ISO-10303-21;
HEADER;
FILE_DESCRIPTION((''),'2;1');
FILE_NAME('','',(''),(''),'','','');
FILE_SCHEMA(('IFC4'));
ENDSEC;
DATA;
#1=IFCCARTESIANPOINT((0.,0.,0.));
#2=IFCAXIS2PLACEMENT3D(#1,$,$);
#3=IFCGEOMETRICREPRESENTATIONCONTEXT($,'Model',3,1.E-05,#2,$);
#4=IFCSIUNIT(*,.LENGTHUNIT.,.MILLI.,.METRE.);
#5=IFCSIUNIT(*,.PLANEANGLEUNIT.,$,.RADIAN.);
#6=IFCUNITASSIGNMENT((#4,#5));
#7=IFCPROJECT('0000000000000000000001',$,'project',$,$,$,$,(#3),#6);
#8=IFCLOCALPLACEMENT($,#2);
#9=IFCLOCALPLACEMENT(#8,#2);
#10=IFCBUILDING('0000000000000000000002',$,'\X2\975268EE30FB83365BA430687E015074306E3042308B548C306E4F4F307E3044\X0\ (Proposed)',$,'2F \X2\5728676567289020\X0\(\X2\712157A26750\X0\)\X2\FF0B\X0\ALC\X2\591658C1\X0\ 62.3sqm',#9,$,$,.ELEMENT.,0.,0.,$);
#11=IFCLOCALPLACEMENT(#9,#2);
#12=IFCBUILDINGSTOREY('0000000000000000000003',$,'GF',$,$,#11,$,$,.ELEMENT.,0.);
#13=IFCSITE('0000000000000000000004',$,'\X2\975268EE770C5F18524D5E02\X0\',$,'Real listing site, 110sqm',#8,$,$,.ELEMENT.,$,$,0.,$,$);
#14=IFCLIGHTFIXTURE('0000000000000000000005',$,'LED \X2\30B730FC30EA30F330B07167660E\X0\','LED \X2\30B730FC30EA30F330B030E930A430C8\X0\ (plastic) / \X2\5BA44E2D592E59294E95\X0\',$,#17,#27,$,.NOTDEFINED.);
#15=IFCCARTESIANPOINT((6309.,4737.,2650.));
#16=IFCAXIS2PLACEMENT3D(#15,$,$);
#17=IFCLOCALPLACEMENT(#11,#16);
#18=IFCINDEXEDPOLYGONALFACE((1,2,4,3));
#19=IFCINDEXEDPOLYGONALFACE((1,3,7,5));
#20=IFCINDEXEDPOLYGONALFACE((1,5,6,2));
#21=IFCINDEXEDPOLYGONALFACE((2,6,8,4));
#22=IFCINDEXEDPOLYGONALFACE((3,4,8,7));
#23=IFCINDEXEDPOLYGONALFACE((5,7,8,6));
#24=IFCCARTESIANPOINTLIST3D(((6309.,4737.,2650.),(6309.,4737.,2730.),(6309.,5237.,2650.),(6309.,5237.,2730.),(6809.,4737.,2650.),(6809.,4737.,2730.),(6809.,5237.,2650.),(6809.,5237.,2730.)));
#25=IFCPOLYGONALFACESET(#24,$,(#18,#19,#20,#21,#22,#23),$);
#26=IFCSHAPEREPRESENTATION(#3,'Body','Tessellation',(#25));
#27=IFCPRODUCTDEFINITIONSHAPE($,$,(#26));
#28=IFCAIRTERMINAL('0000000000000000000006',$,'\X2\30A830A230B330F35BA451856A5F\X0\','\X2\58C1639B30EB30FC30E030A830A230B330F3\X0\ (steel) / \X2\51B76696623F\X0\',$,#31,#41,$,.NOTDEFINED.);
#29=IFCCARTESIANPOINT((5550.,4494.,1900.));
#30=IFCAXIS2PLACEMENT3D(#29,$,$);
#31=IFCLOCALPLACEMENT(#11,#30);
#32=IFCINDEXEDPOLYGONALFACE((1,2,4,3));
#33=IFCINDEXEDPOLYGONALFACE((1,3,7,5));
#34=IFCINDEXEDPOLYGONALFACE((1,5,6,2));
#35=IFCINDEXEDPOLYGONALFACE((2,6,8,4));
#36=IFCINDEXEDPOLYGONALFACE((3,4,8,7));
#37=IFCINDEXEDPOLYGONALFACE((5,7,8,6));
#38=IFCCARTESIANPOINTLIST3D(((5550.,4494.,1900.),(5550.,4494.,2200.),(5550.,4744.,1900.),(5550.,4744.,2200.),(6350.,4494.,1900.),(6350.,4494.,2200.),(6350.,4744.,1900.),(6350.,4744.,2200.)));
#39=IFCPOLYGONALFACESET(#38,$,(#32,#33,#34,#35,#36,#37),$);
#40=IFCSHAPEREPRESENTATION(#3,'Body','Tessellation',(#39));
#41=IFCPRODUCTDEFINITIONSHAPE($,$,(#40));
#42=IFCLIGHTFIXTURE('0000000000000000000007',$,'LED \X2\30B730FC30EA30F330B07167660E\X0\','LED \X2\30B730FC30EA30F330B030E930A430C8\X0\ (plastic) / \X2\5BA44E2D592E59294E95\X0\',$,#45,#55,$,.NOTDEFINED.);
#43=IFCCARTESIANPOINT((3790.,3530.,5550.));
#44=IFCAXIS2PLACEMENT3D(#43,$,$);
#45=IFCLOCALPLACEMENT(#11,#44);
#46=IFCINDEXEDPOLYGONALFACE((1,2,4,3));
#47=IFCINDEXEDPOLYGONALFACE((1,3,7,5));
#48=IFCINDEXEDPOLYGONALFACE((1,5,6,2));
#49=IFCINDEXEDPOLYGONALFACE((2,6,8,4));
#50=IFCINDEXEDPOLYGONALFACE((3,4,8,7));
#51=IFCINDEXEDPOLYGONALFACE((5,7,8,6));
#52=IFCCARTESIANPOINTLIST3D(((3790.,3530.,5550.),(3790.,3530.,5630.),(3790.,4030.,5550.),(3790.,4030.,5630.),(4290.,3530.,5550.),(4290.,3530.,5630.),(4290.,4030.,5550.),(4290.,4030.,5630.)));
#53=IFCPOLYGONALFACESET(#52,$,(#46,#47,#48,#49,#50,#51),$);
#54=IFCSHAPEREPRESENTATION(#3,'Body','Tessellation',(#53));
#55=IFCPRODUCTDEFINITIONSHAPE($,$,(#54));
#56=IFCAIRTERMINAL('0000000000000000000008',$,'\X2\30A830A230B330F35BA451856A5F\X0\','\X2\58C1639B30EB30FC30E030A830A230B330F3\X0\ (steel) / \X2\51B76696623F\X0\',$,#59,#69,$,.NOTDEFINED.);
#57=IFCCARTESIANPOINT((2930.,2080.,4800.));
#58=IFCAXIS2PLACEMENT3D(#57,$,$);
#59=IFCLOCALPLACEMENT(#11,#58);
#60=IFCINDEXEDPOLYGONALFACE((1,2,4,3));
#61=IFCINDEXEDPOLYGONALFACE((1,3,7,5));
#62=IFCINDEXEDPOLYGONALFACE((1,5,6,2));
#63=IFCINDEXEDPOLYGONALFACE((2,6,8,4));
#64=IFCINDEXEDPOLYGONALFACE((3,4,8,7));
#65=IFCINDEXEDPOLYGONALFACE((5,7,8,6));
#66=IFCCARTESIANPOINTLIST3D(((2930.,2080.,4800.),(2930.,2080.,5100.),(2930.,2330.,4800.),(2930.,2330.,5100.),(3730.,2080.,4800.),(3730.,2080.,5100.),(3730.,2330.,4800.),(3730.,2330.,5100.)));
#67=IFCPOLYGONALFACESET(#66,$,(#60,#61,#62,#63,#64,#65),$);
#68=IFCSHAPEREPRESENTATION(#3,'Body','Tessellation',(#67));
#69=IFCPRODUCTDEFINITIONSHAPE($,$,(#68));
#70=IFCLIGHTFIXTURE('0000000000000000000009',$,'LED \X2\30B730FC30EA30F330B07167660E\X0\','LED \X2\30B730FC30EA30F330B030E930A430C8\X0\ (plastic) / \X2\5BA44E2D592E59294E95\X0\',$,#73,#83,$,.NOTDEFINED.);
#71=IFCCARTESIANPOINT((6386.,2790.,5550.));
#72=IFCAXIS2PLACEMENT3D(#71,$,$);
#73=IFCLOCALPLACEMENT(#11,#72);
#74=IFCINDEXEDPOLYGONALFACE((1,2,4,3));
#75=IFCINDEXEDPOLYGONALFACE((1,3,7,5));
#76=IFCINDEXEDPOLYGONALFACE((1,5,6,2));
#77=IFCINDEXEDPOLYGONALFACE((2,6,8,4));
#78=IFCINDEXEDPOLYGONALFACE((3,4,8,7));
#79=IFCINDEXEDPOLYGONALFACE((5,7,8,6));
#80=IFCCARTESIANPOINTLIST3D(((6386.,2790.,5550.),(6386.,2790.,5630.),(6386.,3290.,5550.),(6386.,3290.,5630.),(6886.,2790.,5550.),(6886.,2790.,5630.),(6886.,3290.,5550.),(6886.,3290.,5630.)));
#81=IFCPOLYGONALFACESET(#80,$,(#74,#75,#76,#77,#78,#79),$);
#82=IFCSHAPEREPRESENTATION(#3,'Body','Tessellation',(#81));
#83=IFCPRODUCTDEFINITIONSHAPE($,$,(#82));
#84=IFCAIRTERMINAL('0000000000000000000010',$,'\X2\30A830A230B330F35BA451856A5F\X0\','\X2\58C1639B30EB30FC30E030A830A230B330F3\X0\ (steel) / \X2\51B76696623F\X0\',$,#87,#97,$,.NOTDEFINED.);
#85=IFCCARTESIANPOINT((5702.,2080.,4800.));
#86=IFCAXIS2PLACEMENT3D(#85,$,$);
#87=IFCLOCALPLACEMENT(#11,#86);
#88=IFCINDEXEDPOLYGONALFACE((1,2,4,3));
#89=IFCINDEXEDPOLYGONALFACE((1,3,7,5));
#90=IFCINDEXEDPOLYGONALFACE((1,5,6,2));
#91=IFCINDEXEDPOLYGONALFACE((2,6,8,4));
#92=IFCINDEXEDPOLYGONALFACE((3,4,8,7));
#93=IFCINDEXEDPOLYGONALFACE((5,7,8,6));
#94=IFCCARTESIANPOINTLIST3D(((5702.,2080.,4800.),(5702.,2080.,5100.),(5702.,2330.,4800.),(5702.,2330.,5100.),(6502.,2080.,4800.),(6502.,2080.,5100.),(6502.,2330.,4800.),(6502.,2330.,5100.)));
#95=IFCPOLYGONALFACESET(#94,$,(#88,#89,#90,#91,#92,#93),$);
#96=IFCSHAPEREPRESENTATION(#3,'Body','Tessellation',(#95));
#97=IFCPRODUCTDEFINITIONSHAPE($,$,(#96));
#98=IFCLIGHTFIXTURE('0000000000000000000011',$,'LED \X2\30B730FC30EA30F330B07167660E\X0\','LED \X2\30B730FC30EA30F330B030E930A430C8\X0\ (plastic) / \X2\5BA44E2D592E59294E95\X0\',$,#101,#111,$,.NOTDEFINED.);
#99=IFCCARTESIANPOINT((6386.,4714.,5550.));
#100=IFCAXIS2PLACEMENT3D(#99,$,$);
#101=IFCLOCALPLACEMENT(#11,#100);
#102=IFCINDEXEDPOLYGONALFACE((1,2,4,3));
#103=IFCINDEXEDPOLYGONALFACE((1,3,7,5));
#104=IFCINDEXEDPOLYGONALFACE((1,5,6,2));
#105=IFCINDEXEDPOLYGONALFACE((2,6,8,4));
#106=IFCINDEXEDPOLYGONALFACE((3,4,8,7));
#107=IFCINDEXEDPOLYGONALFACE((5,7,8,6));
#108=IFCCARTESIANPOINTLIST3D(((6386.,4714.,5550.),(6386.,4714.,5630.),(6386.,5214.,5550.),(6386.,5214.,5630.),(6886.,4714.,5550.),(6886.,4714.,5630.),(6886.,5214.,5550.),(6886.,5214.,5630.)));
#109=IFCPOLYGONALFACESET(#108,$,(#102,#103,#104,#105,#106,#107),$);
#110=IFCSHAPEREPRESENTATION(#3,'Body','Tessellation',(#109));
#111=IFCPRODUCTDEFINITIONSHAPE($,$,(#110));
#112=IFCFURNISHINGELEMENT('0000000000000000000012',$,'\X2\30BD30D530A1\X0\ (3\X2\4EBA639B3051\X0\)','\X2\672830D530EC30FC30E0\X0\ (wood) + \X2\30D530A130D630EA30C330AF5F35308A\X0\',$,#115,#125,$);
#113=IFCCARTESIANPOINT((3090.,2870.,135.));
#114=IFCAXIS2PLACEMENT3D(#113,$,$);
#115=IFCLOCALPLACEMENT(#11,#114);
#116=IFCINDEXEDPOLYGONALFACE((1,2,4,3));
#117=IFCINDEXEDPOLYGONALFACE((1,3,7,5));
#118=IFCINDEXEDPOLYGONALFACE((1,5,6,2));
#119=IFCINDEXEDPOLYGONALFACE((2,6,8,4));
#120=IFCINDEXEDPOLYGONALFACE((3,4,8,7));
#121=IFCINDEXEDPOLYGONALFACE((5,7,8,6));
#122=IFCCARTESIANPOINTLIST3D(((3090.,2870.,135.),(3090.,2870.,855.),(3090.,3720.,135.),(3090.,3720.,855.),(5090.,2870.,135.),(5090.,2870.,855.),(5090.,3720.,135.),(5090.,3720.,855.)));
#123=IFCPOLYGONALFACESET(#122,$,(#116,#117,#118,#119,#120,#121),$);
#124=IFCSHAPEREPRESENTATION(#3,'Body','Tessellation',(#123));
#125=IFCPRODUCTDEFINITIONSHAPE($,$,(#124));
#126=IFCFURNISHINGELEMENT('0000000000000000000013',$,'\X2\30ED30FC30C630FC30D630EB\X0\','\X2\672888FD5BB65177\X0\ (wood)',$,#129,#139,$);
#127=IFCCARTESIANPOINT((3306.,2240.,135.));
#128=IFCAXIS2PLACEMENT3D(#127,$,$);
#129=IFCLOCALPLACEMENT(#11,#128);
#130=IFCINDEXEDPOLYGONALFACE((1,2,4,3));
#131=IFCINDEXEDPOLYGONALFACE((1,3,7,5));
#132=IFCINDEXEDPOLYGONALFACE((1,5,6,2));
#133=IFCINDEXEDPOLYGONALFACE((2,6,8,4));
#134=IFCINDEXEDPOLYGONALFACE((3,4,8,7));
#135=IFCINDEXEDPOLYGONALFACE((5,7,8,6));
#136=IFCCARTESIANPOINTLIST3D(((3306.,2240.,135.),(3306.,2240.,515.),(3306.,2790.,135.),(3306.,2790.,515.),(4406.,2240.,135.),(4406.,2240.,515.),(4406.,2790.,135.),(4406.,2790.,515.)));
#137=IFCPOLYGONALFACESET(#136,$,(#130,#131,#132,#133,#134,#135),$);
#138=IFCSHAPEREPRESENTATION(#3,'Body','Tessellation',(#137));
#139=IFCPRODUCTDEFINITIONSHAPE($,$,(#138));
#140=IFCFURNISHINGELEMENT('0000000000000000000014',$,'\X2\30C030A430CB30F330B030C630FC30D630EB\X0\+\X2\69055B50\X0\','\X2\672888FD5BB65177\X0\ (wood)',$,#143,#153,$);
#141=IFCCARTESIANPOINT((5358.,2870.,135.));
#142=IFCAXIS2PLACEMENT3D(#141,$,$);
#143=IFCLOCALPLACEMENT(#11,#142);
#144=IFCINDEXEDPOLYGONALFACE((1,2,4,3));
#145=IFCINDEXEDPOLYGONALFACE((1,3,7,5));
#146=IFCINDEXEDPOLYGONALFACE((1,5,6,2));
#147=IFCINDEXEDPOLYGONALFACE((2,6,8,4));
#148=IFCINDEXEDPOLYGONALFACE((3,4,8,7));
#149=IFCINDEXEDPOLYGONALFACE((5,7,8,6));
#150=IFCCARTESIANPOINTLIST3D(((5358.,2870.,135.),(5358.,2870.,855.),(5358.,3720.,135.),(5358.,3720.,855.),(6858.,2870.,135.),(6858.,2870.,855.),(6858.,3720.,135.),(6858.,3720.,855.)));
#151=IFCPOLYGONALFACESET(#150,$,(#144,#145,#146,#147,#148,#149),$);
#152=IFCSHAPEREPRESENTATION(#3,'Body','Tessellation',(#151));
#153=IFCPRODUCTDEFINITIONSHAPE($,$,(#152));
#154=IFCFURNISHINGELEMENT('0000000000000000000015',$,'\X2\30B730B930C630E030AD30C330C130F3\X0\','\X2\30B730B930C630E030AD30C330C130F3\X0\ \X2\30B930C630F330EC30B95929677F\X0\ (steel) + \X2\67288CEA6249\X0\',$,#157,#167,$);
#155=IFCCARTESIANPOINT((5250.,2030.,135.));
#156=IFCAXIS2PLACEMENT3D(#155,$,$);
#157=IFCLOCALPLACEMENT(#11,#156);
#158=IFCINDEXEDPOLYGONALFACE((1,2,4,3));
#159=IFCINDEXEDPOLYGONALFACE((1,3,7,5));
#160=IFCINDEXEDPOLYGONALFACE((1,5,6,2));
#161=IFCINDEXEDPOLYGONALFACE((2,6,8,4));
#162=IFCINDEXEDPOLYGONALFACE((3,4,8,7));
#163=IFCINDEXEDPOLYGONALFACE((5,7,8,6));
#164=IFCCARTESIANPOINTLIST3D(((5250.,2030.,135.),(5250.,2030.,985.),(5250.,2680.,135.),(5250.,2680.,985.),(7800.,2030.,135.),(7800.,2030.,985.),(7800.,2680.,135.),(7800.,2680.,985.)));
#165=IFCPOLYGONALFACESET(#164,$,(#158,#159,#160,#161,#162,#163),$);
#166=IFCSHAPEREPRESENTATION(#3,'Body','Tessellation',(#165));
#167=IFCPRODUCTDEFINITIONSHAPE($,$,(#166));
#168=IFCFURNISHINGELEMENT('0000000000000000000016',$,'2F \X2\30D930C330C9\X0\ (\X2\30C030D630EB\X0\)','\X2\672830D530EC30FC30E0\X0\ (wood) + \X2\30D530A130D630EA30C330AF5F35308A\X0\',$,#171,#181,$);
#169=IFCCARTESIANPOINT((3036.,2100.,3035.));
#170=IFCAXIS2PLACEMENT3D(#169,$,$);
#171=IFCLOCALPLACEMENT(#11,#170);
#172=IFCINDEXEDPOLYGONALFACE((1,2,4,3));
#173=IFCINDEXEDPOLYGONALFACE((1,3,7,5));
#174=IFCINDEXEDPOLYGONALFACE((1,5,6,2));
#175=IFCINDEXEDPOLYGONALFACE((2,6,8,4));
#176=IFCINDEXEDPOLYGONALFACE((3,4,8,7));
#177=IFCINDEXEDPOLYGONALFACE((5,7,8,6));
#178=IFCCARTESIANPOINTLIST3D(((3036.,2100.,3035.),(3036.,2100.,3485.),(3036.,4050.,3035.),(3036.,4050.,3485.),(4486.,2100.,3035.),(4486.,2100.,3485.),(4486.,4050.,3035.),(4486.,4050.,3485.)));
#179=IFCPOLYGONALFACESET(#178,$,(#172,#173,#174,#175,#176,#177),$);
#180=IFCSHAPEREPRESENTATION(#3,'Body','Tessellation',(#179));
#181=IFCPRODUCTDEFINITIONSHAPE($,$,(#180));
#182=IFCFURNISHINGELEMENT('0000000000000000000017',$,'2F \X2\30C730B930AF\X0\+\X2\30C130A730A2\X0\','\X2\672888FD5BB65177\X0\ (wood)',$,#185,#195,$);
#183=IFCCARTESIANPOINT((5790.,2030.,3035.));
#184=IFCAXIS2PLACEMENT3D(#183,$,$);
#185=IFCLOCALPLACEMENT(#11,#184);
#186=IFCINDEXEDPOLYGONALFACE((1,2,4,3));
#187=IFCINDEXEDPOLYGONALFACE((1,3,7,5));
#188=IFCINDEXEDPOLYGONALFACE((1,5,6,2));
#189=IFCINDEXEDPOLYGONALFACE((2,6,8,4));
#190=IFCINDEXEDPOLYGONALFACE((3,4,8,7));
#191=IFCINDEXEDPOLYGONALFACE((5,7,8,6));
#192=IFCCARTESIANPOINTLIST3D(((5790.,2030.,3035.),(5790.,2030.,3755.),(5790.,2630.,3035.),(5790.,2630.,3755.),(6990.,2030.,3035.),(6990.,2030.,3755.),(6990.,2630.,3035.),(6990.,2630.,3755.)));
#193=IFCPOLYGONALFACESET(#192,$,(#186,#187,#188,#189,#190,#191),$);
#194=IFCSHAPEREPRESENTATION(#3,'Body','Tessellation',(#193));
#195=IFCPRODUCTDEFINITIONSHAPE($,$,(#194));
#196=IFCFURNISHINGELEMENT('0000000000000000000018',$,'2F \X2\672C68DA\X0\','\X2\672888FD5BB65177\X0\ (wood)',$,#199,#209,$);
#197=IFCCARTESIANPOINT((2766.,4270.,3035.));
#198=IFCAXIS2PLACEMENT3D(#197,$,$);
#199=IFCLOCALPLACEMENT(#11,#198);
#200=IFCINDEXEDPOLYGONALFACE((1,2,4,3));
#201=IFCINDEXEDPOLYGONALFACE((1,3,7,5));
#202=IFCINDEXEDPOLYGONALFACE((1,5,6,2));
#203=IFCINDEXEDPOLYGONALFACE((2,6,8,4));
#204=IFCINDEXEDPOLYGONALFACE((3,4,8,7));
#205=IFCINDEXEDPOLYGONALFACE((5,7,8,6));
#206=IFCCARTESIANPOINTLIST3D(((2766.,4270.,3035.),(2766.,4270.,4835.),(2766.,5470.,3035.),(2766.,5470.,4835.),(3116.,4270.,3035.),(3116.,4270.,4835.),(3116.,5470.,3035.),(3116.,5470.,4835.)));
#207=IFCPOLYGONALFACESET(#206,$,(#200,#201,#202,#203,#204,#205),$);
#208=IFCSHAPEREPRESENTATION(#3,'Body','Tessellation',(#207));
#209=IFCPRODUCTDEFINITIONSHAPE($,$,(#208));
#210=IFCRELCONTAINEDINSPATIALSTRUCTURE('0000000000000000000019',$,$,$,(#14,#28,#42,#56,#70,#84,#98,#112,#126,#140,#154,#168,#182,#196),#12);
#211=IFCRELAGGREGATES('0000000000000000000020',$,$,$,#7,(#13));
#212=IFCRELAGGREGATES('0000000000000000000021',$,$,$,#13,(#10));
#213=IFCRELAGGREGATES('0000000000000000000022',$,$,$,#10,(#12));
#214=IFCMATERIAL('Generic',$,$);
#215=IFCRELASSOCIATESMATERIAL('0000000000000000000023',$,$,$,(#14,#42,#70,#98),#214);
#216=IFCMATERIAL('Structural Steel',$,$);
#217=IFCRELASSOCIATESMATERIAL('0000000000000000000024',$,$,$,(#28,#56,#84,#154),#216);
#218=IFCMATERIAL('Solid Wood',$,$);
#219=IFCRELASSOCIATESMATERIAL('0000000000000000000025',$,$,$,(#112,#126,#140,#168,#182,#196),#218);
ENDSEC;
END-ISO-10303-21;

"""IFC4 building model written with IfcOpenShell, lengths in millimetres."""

from ifc_helpers import new_model, si_unit, frame, frame_2d, origin, place, context, project, spatial, rectangle, extrude, material, element, save


model = new_model("IFC4")

# Units and contexts
model_context = context("Model", 3, precision=1e-05, world=origin())
ifc_project = project(units=[si_unit("LENGTHUNIT", "METRE", prefix="MILLI"), si_unit("PLANEANGLEUNIT", "RADIAN")], contexts=[model_context])

# Site, building, storey
site_placement = place(None, origin())
site = spatial("IfcSite", under=ifc_project, at=site_placement, Name="青森県弘前市", ObjectType="Real listing site, 110sqm", CompositionType="ELEMENT", RefElevation=0.0)
building_placement = place(site_placement, origin())
building = spatial("IfcBuilding", under=site, at=building_placement, Name="青森・茶室と縁側のある和の住まい (Proposed)", ObjectType="2F 在来木造(無垢材)＋ALC外壁 62.3sqm", CompositionType="ELEMENT", ElevationOfRefHeight=0.0, ElevationOfTerrain=0.0)
storey_placement = place(building_placement, origin())
storey = spatial("IfcBuildingStorey", under=building, at=storey_placement, Name="GF", CompositionType="ELEMENT", Elevation=0.0)

# Shared definitions
ifc_material_1 = material(Name="Solid Wood")

# Shared definitions
ifc_material_2 = material(Name="Structural Steel")

# Shared definitions
ifc_material_3 = material(Name="Generic")

# Light fixture
light_fixture_1_placement = place(storey_placement, frame((6309.0, 4737.0, 2650.0)))
element("IfcLightFixture", 1, at=light_fixture_1_placement, inside=storey, material=ifc_material_3, Name="LED シーリング照明", Description="LED シーリングライト (plastic) / 室中央天井", PredefinedType="NOTDEFINED", context=model_context, shape_type="SweptSolid", body=[
    extrude(rectangle(XDim=500.0, YDim=500.0, at=frame_2d((250.0, 250.0))), frame((6309.0, 4737.0, 2650.0)), (0.0, 0.0, 1.0), 80.0),
])

# Air terminal
air_terminal_1_placement = place(storey_placement, frame((5550.0, 4494.0, 1900.0)))
element("IfcAirTerminal", 2, at=air_terminal_1_placement, inside=storey, material=ifc_material_2, Name="エアコン室内機", Description="壁掛ルームエアコン (steel) / 冷暖房", PredefinedType="NOTDEFINED", context=model_context, shape_type="SweptSolid", body=[
    extrude(rectangle(XDim=800.0, YDim=250.0, at=frame_2d((400.0, 125.0))), frame((5550.0, 4494.0, 1900.0)), (0.0, 0.0, 1.0), 300.0),
])

# Light fixture
light_fixture_2_placement = place(storey_placement, frame((3790.0, 3530.0, 5550.0)))
element("IfcLightFixture", 3, at=light_fixture_2_placement, inside=storey, material=ifc_material_3, Name="LED シーリング照明", Description="LED シーリングライト (plastic) / 室中央天井", PredefinedType="NOTDEFINED", context=model_context, shape_type="SweptSolid", body=[
    extrude(rectangle(XDim=500.0, YDim=500.0, at=frame_2d((250.0, 250.0))), frame((3790.0, 3530.0, 5550.0)), (0.0, 0.0, 1.0), 80.0),
])

# Air terminal
air_terminal_2_placement = place(storey_placement, frame((2930.0, 2080.0, 4800.0)))
element("IfcAirTerminal", 4, at=air_terminal_2_placement, inside=storey, material=ifc_material_2, Name="エアコン室内機", Description="壁掛ルームエアコン (steel) / 冷暖房", PredefinedType="NOTDEFINED", context=model_context, shape_type="SweptSolid", body=[
    extrude(rectangle(XDim=800.0, YDim=250.0, at=frame_2d((400.0, 125.0))), frame((2930.0, 2080.0, 4800.0)), (0.0, 0.0, 1.0), 300.0),
])

# Light fixture
light_fixture_3_placement = place(storey_placement, frame((6386.0, 2790.0, 5550.0)))
element("IfcLightFixture", 5, at=light_fixture_3_placement, inside=storey, material=ifc_material_3, Name="LED シーリング照明", Description="LED シーリングライト (plastic) / 室中央天井", PredefinedType="NOTDEFINED", context=model_context, shape_type="SweptSolid", body=[
    extrude(rectangle(XDim=500.0, YDim=500.0, at=frame_2d((250.0, 250.0))), frame((6386.0, 2790.0, 5550.0)), (0.0, 0.0, 1.0), 80.0),
])

# Air terminal
air_terminal_3_placement = place(storey_placement, frame((5702.0, 2080.0, 4800.0)))
element("IfcAirTerminal", 6, at=air_terminal_3_placement, inside=storey, material=ifc_material_2, Name="エアコン室内機", Description="壁掛ルームエアコン (steel) / 冷暖房", PredefinedType="NOTDEFINED", context=model_context, shape_type="SweptSolid", body=[
    extrude(rectangle(XDim=800.0, YDim=250.0, at=frame_2d((400.0, 125.0))), frame((5702.0, 2080.0, 4800.0)), (0.0, 0.0, 1.0), 300.0),
])

# Light fixture
light_fixture_4_placement = place(storey_placement, frame((6386.0, 4714.0, 5550.0)))
element("IfcLightFixture", 7, at=light_fixture_4_placement, inside=storey, material=ifc_material_3, Name="LED シーリング照明", Description="LED シーリングライト (plastic) / 室中央天井", PredefinedType="NOTDEFINED", context=model_context, shape_type="SweptSolid", body=[
    extrude(rectangle(XDim=500.0, YDim=500.0, at=frame_2d((250.0, 250.0))), frame((6386.0, 4714.0, 5550.0)), (0.0, 0.0, 1.0), 80.0),
])

# Furnishing elements
furnishing_1_placement = place(storey_placement, frame((3090.0, 2870.0, 135.0)))
element("IfcFurnishingElement", 8, at=furnishing_1_placement, inside=storey, material=ifc_material_1, Name="ソファ (3人掛け)", Description="木フレーム (wood) + ファブリック張り", context=model_context, shape_type="SweptSolid", body=[
    extrude(rectangle(XDim=2000.0, YDim=850.0, at=frame_2d((1000.0, 425.0))), frame((3090.0, 2870.0, 135.0)), (0.0, 0.0, 1.0), 720.0),
])
furnishing_2_placement = place(storey_placement, frame((3306.0, 2240.0, 135.0)))
element("IfcFurnishingElement", 9, at=furnishing_2_placement, inside=storey, material=ifc_material_1, Name="ローテーブル", Description="木製家具 (wood)", context=model_context, shape_type="SweptSolid", body=[
    extrude(rectangle(XDim=1100.0, YDim=550.0, at=frame_2d((550.0, 275.0))), frame((3306.0, 2240.0, 135.0)), (0.0, 0.0, 1.0), 380.0),
])
furnishing_3_placement = place(storey_placement, frame((5358.0, 2870.0, 135.0)))
element("IfcFurnishingElement", 10, at=furnishing_3_placement, inside=storey, material=ifc_material_1, Name="ダイニングテーブル+椅子", Description="木製家具 (wood)", context=model_context, shape_type="SweptSolid", body=[
    extrude(rectangle(XDim=1500.0, YDim=850.0, at=frame_2d((750.0, 425.0))), frame((5358.0, 2870.0, 135.0)), (0.0, 0.0, 1.0), 720.0),
])
furnishing_4_placement = place(storey_placement, frame((5250.0, 2030.0, 135.0)))
element("IfcFurnishingElement", 11, at=furnishing_4_placement, inside=storey, material=ifc_material_2, Name="システムキッチン", Description="システムキッチン ステンレス天板 (steel) + 木質扉", context=model_context, shape_type="SweptSolid", body=[
    extrude(rectangle(XDim=2550.0, YDim=650.0, at=frame_2d((1275.0, 325.0))), frame((5250.0, 2030.0, 135.0)), (0.0, 0.0, 1.0), 850.0),
])
furnishing_5_placement = place(storey_placement, frame((3036.0, 2100.0, 3035.0)))
element("IfcFurnishingElement", 12, at=furnishing_5_placement, inside=storey, material=ifc_material_1, Name="2F ベッド (ダブル)", Description="木フレーム (wood) + ファブリック張り", context=model_context, shape_type="SweptSolid", body=[
    extrude(rectangle(XDim=1450.0, YDim=1950.0, at=frame_2d((725.0, 975.0))), frame((3036.0, 2100.0, 3035.0)), (0.0, 0.0, 1.0), 450.0),
])
furnishing_6_placement = place(storey_placement, frame((5790.0, 2030.0, 3035.0)))
element("IfcFurnishingElement", 13, at=furnishing_6_placement, inside=storey, material=ifc_material_1, Name="2F デスク+チェア", Description="木製家具 (wood)", context=model_context, shape_type="SweptSolid", body=[
    extrude(rectangle(XDim=1200.0, YDim=600.0, at=frame_2d((600.0, 300.0))), frame((5790.0, 2030.0, 3035.0)), (0.0, 0.0, 1.0), 720.0),
])
furnishing_7_placement = place(storey_placement, frame((2766.0, 4270.0, 3035.0)))
element("IfcFurnishingElement", 14, at=furnishing_7_placement, inside=storey, material=ifc_material_1, Name="2F 本棚", Description="木製家具 (wood)", context=model_context, shape_type="SweptSolid", body=[
    extrude(rectangle(XDim=350.0, YDim=1200.0, at=frame_2d((175.0, 600.0))), frame((2766.0, 4270.0, 3035.0)), (0.0, 0.0, 1.0), 1800.0),
])

save(model, "model.ifc")
